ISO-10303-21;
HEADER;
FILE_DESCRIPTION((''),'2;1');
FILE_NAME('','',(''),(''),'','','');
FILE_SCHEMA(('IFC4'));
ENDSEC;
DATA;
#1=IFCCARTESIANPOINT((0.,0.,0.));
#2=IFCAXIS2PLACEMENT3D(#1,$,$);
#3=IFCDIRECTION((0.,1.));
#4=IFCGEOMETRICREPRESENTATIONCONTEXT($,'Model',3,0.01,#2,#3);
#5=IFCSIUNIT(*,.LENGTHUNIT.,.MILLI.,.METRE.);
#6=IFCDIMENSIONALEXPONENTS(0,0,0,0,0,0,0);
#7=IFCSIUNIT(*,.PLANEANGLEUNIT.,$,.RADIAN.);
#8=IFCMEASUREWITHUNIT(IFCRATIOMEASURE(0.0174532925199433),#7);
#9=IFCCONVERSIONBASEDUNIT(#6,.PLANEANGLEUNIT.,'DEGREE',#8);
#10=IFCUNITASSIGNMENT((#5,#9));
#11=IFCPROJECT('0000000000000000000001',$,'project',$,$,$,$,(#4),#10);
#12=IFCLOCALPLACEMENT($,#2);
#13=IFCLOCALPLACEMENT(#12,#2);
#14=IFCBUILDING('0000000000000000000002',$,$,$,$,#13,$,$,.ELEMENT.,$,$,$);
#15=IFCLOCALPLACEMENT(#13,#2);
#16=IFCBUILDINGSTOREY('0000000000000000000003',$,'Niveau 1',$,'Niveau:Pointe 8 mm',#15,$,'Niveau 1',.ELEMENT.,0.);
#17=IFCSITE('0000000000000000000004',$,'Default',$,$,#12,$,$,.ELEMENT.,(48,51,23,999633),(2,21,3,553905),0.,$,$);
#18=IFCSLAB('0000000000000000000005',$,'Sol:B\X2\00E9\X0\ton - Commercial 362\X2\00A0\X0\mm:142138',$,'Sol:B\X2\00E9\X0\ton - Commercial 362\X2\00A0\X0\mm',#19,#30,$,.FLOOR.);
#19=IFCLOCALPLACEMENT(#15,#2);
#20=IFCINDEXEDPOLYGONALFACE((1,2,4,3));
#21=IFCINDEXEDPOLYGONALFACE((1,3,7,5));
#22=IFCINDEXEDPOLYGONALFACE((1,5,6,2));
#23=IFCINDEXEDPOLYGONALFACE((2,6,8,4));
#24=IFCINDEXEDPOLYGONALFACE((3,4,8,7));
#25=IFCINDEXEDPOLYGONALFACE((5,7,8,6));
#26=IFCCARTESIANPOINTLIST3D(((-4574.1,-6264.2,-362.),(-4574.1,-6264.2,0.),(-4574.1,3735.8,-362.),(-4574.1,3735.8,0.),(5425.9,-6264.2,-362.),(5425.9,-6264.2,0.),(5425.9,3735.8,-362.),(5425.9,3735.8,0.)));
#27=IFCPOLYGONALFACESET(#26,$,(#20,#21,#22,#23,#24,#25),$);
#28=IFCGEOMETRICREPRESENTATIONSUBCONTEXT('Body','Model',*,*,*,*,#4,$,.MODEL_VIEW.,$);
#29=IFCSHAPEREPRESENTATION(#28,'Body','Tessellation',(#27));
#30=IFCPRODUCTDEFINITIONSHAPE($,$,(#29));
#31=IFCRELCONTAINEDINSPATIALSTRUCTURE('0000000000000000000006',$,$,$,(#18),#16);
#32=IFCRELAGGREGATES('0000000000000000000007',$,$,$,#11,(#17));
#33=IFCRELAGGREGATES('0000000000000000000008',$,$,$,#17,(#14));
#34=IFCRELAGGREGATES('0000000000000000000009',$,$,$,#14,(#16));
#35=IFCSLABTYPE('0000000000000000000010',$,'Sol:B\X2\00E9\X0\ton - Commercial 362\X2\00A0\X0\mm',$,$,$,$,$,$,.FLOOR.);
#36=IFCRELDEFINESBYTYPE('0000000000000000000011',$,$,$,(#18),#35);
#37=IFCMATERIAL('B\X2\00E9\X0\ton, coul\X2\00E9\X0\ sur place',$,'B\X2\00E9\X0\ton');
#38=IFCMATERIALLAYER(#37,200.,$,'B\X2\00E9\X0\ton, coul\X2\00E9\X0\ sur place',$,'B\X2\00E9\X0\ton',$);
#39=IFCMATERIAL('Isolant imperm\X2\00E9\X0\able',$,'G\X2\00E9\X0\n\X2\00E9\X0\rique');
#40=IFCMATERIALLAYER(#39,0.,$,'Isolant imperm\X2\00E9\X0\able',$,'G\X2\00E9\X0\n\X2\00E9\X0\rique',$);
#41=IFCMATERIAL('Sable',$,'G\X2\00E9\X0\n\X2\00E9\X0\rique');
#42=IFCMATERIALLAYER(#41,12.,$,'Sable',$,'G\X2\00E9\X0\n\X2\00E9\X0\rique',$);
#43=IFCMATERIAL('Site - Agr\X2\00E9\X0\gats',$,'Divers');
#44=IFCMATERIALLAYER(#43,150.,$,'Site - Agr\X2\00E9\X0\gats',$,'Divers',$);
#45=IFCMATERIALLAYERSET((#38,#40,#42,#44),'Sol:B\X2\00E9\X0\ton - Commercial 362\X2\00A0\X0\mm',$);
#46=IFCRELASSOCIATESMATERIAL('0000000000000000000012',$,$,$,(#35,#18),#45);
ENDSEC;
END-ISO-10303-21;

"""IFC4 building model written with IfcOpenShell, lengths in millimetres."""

from ifc_helpers import new_model, entity, si_unit, converted_unit, direction, frame, frame_2d, origin, place, context, subcontext, project, spatial, rectangle, extrude, material, layer, layer_set, layer_usage, type_object, element, save


model = new_model("IFC4")

# Units and contexts
model_context = context("Model", 3, precision=0.01, world=origin(), true_north=direction((0.0, 1.0)))
body_context = subcontext(model_context, "Body", "Model", "MODEL_VIEW")
ifc_project = project(units=[si_unit("LENGTHUNIT", "METRE", prefix="MILLI"), converted_unit("PLANEANGLEUNIT", "DEGREE", entity("IfcRatioMeasure", 0.0174532925199433), si_unit("PLANEANGLEUNIT", "RADIAN"), dimensions=[0, 0, 0, 0, 0, 0, 0])], contexts=[model_context])

# Site, building, storey
site_placement = place(None, origin())
site = spatial("IfcSite", under=ifc_project, at=site_placement, Name="Default", CompositionType="ELEMENT", RefLatitude=(48, 51, 23, 999633), RefLongitude=(2, 21, 3, 553905), RefElevation=0.0)
building_placement = place(site_placement, origin())
building = spatial("IfcBuilding", under=site, at=building_placement, CompositionType="ELEMENT")
storey_placement = place(building_placement, origin())
storey = spatial("IfcBuildingStorey", under=building, at=storey_placement, Name="Niveau 1", ObjectType="Niveau:Pointe 8 mm", LongName="Niveau 1", CompositionType="ELEMENT", Elevation=0.0)

# Slab
ifc_material_1 = material(Name="Béton, coulé sur place", Category="Béton")
ifc_layer_1 = layer(ifc_material_1, 200.0, Name="Béton, coulé sur place", Category="Béton")
ifc_material_2 = material(Name="Isolant imperméable", Category="Générique")
ifc_layer_2 = layer(ifc_material_2, 0.0, Name="Isolant imperméable", Category="Générique")
ifc_material_3 = material(Name="Sable", Category="Générique")
ifc_layer_3 = layer(ifc_material_3, 12.0, Name="Sable", Category="Générique")
ifc_material_4 = material(Name="Site - Agrégats", Category="Divers")
ifc_layer_4 = layer(ifc_material_4, 150.0, Name="Site - Agrégats", Category="Divers")
ifc_layer_set = layer_set([ifc_layer_1, ifc_layer_2, ifc_layer_3, ifc_layer_4], Name="Sol:Béton - Commercial 362 mm")
ifc_layer_usage = layer_usage(ifc_layer_set, "AXIS3", "POSITIVE", 0.0)
slab_type = type_object("IfcSlabType", Name="Sol:Béton - Commercial 362 mm", PredefinedType="FLOOR", material=ifc_layer_set)
slab_placement = place(storey_placement, origin())
element("IfcSlab", 1, at=slab_placement, inside=storey, type_object=slab_type, material=ifc_layer_usage, Name="Sol:Béton - Commercial 362 mm:142138", ObjectType="Sol:Béton - Commercial 362 mm", PredefinedType="FLOOR", context=body_context, shape_type="SweptSolid", body=[
    extrude(rectangle(XDim=10000.0, YDim=10000.0, at=frame_2d((0.0, 0.0), x_axis=(1.0, 0.0))), frame((425.9, -1264.2, 0.0), z_axis=(0.0, 0.0, -1.0), x_axis=(0.0, 1.0, 0.0)), (0.0, 0.0, 1.0), 362.0),
])

save(model, "model.ifc")
